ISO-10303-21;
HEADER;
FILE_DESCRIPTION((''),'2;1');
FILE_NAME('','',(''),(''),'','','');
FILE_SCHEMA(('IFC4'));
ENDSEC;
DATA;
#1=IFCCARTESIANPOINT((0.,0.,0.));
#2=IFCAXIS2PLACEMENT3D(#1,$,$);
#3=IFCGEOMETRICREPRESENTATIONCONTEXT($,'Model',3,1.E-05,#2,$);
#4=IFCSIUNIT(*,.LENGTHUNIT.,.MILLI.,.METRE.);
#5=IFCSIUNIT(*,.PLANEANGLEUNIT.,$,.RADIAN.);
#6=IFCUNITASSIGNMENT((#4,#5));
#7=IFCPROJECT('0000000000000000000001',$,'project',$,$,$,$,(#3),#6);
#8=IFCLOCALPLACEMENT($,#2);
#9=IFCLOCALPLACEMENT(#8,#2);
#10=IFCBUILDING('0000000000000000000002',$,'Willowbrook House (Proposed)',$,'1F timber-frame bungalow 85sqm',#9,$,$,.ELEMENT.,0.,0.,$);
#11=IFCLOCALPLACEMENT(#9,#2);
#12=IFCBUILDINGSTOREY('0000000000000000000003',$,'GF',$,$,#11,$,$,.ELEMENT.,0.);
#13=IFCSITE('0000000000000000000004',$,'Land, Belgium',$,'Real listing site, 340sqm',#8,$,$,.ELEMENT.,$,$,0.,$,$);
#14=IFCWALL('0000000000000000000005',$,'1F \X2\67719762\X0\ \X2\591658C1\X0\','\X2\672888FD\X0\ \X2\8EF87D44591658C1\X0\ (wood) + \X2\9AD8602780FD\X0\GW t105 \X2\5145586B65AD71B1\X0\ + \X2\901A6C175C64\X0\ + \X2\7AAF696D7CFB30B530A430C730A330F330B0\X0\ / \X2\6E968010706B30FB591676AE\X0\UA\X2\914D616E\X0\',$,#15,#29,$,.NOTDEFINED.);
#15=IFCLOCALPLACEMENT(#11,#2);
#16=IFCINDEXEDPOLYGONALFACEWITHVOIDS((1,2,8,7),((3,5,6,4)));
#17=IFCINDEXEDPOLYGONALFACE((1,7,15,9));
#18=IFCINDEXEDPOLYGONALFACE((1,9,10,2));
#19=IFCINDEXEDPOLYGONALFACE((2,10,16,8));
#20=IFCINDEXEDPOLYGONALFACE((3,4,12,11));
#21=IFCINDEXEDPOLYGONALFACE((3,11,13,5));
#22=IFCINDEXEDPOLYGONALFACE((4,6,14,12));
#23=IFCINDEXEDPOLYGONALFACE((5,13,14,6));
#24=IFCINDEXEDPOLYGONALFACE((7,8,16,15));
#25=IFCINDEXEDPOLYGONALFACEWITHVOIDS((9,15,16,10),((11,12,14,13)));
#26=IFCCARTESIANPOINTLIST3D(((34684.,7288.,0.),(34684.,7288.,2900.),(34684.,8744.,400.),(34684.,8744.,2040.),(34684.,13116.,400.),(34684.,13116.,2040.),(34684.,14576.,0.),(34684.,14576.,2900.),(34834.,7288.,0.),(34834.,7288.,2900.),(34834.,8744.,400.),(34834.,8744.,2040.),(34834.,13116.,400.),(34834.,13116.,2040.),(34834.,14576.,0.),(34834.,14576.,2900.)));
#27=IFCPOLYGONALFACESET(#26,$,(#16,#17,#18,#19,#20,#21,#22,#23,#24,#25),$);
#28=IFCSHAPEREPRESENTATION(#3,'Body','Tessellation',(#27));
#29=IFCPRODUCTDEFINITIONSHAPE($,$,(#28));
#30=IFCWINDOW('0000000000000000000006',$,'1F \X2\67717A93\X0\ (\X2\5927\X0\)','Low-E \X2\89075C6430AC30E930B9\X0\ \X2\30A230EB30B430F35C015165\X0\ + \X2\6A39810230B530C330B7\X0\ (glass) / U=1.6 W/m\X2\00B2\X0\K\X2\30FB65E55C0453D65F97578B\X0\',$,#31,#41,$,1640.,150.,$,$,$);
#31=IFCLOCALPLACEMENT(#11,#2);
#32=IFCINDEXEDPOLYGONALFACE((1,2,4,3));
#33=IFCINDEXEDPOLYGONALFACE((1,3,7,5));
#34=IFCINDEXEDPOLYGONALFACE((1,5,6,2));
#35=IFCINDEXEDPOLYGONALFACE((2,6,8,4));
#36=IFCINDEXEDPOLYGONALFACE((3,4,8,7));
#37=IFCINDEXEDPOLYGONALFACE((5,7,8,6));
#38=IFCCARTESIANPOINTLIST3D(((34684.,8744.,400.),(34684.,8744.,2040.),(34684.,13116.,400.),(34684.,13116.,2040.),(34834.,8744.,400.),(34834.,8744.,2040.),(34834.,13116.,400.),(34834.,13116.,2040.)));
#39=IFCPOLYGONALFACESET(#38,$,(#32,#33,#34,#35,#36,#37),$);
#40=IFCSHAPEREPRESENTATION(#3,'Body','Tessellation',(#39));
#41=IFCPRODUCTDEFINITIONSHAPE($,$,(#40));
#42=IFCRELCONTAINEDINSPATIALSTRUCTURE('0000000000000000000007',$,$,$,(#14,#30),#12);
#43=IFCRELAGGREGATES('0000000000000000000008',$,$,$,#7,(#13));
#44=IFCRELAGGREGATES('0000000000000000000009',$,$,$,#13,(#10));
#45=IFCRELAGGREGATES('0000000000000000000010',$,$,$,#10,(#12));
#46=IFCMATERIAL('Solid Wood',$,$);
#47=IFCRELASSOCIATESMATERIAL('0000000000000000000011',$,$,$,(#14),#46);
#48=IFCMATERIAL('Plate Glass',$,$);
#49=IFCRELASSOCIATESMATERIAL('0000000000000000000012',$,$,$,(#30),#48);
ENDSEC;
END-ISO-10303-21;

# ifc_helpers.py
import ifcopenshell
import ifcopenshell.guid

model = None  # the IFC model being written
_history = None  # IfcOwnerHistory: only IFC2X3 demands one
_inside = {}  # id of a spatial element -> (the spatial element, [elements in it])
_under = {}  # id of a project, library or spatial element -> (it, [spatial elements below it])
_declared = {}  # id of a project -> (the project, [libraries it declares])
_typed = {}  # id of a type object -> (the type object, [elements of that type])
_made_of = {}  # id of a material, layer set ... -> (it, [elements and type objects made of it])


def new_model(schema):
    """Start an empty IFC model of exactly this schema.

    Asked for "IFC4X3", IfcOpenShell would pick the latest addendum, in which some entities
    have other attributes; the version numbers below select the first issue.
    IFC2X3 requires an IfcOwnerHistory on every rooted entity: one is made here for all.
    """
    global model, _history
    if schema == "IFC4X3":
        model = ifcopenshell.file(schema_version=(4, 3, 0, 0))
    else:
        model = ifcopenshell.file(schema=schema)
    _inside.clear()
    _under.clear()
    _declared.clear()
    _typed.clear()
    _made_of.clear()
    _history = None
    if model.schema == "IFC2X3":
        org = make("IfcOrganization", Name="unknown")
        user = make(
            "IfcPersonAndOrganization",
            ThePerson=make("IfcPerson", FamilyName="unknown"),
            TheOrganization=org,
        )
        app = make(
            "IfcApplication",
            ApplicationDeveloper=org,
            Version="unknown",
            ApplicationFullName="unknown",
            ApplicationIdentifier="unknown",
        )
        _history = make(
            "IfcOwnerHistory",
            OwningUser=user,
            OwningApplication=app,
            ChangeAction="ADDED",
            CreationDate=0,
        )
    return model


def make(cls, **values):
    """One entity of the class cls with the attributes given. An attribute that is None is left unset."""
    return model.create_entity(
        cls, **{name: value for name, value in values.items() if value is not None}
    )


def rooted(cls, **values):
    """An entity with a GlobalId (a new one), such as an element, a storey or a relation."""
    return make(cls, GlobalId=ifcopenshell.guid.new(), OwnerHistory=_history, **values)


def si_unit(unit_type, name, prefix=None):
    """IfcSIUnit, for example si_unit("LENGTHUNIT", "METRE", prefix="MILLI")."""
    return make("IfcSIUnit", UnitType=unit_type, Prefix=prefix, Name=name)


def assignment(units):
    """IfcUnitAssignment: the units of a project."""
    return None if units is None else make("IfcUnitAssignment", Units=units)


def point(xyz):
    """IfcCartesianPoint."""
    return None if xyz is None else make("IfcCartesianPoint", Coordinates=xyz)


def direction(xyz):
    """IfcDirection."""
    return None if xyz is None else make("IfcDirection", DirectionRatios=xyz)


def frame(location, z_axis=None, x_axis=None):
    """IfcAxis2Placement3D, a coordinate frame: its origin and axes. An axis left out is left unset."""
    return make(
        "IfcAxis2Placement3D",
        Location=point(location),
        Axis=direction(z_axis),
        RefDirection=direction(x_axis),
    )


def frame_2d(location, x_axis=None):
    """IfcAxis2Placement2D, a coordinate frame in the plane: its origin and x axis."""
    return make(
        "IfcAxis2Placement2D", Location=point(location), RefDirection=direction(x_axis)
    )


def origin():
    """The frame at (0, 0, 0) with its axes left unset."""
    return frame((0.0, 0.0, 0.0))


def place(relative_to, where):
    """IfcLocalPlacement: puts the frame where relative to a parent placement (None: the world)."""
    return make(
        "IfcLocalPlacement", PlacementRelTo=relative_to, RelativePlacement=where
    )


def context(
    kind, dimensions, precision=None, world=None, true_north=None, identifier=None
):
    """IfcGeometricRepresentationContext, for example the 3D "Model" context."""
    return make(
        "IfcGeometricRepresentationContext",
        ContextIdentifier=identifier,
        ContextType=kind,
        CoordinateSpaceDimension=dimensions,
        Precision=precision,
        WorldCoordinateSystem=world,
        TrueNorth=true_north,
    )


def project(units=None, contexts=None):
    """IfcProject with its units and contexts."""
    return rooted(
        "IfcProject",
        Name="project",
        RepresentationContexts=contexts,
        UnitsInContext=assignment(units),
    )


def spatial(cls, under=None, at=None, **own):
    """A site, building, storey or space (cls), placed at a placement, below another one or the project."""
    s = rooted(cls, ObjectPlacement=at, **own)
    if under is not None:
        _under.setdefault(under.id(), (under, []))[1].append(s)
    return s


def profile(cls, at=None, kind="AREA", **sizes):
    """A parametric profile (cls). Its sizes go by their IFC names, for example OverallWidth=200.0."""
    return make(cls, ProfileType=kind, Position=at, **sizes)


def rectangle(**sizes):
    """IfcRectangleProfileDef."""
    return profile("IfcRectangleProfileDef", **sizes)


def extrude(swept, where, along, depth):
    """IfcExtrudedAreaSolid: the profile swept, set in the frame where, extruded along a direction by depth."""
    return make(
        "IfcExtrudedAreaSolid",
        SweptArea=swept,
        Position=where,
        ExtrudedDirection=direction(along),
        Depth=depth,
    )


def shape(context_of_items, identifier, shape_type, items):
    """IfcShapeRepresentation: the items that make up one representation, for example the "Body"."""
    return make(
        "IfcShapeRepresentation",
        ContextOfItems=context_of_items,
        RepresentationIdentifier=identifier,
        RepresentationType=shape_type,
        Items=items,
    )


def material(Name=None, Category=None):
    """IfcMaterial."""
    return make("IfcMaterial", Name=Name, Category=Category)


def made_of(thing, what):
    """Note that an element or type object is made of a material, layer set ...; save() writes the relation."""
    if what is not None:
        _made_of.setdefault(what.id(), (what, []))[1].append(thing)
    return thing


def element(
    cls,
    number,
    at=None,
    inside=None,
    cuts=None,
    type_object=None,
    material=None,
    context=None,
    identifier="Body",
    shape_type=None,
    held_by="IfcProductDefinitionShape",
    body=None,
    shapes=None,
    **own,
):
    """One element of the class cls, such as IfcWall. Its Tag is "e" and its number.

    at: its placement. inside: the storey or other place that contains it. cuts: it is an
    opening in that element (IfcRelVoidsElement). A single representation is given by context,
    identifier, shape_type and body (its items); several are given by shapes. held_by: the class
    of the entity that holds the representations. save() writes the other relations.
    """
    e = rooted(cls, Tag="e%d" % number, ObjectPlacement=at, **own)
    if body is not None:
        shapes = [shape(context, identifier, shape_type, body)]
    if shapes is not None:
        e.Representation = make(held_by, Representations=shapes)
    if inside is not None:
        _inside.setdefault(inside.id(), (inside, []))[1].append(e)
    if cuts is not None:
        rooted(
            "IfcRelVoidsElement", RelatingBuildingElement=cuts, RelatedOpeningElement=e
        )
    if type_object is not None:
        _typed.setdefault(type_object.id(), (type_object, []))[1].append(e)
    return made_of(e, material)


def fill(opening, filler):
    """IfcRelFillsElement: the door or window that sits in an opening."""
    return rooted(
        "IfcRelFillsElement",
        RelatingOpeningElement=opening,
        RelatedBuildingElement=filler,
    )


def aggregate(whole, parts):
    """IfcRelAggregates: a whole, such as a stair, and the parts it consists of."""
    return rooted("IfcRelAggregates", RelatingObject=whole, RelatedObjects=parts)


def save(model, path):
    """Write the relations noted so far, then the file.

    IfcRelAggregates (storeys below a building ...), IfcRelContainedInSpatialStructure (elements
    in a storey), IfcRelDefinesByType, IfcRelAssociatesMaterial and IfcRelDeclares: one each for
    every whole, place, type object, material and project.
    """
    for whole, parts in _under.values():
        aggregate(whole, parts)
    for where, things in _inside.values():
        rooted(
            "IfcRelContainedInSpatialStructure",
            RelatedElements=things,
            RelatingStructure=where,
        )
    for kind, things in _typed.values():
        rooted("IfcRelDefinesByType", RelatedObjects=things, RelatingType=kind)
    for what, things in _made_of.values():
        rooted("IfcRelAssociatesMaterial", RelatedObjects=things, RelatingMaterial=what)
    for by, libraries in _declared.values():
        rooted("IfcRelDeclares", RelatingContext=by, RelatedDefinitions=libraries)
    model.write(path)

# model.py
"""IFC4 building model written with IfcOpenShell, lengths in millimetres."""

from ifc_helpers import new_model, si_unit, frame, frame_2d, origin, place, context, project, spatial, rectangle, extrude, material, element, fill, save


model = new_model("IFC4")

# Units and contexts
model_context = context("Model", 3, precision=1e-05, world=origin())
ifc_project = project(units=[si_unit("LENGTHUNIT", "METRE", prefix="MILLI"), si_unit("PLANEANGLEUNIT", "RADIAN")], contexts=[model_context])

# Site, building, storey
site_placement = place(None, origin())
site = spatial("IfcSite", under=ifc_project, at=site_placement, Name="Land, Belgium", ObjectType="Real listing site, 340sqm", CompositionType="ELEMENT", RefElevation=0.0)
building_placement = place(site_placement, origin())
building = spatial("IfcBuilding", under=site, at=building_placement, Name="Willowbrook House (Proposed)", ObjectType="1F timber-frame bungalow 85sqm", CompositionType="ELEMENT", ElevationOfRefHeight=0.0, ElevationOfTerrain=0.0)
storey_placement = place(building_placement, origin())
storey = spatial("IfcBuildingStorey", under=building, at=storey_placement, Name="GF", CompositionType="ELEMENT", Elevation=0.0)

# Shared definitions
ifc_material_1 = material(Name="Solid Wood")

# Wall, opening, window
wall_1_placement = place(storey_placement, frame((17342.0, 3644.0, 0.0)))
wall_1 = element("IfcWall", 1, at=wall_1_placement, inside=storey, material=ifc_material_1, Name="1F 東面 外壁", Description="木製 軸組外壁 (wood) + 高性能GW t105 充填断熱 + 通気層 + 窯業系サイディング / 準耐火・外皮UA配慮", PredefinedType="NOTDEFINED", context=model_context, shape_type="SweptSolid", body=[
    extrude(rectangle(XDim=150.0, YDim=7288.0, at=frame_2d((75.0, 3644.0))), frame((17342.0, 3644.0, 0.0)), (0.0, 0.0, 1.0), 2900.0),
])
opening_placement = place(storey_placement, frame((17342.0, 4372.0, 200.0)))
opening = element("IfcOpeningElement", 2, at=opening_placement, cuts=wall_1, PredefinedType="NOTDEFINED", context=model_context, shape_type="SweptSolid", body=[
    extrude(rectangle(XDim=150.0, YDim=4372.0, at=frame_2d((75.0, 2186.0))), frame((17342.0, 4372.0, 200.0)), (0.0, 0.0, 1.0), 1640.0),
])
ifc_material_2 = material(Name="Plate Glass")
window_placement = place(storey_placement, frame((17342.0, 4372.0, 200.0)))
window = element("IfcWindow", 3, at=window_placement, inside=storey, material=ifc_material_2, Name="1F 東窓 (大)", Description="Low-E 複層ガラス アルゴン封入 + 樹脂サッシ (glass) / U=1.6 W/m²K・日射取得型", OverallHeight=1640.0, OverallWidth=150.0, context=model_context, shape_type="SweptSolid", body=[
    extrude(rectangle(XDim=150.0, YDim=4372.0, at=frame_2d((75.0, 2186.0))), frame((17342.0, 4372.0, 200.0)), (0.0, 0.0, 1.0), 1640.0),
])
fill(opening, window)

save(model, "model.ifc")
